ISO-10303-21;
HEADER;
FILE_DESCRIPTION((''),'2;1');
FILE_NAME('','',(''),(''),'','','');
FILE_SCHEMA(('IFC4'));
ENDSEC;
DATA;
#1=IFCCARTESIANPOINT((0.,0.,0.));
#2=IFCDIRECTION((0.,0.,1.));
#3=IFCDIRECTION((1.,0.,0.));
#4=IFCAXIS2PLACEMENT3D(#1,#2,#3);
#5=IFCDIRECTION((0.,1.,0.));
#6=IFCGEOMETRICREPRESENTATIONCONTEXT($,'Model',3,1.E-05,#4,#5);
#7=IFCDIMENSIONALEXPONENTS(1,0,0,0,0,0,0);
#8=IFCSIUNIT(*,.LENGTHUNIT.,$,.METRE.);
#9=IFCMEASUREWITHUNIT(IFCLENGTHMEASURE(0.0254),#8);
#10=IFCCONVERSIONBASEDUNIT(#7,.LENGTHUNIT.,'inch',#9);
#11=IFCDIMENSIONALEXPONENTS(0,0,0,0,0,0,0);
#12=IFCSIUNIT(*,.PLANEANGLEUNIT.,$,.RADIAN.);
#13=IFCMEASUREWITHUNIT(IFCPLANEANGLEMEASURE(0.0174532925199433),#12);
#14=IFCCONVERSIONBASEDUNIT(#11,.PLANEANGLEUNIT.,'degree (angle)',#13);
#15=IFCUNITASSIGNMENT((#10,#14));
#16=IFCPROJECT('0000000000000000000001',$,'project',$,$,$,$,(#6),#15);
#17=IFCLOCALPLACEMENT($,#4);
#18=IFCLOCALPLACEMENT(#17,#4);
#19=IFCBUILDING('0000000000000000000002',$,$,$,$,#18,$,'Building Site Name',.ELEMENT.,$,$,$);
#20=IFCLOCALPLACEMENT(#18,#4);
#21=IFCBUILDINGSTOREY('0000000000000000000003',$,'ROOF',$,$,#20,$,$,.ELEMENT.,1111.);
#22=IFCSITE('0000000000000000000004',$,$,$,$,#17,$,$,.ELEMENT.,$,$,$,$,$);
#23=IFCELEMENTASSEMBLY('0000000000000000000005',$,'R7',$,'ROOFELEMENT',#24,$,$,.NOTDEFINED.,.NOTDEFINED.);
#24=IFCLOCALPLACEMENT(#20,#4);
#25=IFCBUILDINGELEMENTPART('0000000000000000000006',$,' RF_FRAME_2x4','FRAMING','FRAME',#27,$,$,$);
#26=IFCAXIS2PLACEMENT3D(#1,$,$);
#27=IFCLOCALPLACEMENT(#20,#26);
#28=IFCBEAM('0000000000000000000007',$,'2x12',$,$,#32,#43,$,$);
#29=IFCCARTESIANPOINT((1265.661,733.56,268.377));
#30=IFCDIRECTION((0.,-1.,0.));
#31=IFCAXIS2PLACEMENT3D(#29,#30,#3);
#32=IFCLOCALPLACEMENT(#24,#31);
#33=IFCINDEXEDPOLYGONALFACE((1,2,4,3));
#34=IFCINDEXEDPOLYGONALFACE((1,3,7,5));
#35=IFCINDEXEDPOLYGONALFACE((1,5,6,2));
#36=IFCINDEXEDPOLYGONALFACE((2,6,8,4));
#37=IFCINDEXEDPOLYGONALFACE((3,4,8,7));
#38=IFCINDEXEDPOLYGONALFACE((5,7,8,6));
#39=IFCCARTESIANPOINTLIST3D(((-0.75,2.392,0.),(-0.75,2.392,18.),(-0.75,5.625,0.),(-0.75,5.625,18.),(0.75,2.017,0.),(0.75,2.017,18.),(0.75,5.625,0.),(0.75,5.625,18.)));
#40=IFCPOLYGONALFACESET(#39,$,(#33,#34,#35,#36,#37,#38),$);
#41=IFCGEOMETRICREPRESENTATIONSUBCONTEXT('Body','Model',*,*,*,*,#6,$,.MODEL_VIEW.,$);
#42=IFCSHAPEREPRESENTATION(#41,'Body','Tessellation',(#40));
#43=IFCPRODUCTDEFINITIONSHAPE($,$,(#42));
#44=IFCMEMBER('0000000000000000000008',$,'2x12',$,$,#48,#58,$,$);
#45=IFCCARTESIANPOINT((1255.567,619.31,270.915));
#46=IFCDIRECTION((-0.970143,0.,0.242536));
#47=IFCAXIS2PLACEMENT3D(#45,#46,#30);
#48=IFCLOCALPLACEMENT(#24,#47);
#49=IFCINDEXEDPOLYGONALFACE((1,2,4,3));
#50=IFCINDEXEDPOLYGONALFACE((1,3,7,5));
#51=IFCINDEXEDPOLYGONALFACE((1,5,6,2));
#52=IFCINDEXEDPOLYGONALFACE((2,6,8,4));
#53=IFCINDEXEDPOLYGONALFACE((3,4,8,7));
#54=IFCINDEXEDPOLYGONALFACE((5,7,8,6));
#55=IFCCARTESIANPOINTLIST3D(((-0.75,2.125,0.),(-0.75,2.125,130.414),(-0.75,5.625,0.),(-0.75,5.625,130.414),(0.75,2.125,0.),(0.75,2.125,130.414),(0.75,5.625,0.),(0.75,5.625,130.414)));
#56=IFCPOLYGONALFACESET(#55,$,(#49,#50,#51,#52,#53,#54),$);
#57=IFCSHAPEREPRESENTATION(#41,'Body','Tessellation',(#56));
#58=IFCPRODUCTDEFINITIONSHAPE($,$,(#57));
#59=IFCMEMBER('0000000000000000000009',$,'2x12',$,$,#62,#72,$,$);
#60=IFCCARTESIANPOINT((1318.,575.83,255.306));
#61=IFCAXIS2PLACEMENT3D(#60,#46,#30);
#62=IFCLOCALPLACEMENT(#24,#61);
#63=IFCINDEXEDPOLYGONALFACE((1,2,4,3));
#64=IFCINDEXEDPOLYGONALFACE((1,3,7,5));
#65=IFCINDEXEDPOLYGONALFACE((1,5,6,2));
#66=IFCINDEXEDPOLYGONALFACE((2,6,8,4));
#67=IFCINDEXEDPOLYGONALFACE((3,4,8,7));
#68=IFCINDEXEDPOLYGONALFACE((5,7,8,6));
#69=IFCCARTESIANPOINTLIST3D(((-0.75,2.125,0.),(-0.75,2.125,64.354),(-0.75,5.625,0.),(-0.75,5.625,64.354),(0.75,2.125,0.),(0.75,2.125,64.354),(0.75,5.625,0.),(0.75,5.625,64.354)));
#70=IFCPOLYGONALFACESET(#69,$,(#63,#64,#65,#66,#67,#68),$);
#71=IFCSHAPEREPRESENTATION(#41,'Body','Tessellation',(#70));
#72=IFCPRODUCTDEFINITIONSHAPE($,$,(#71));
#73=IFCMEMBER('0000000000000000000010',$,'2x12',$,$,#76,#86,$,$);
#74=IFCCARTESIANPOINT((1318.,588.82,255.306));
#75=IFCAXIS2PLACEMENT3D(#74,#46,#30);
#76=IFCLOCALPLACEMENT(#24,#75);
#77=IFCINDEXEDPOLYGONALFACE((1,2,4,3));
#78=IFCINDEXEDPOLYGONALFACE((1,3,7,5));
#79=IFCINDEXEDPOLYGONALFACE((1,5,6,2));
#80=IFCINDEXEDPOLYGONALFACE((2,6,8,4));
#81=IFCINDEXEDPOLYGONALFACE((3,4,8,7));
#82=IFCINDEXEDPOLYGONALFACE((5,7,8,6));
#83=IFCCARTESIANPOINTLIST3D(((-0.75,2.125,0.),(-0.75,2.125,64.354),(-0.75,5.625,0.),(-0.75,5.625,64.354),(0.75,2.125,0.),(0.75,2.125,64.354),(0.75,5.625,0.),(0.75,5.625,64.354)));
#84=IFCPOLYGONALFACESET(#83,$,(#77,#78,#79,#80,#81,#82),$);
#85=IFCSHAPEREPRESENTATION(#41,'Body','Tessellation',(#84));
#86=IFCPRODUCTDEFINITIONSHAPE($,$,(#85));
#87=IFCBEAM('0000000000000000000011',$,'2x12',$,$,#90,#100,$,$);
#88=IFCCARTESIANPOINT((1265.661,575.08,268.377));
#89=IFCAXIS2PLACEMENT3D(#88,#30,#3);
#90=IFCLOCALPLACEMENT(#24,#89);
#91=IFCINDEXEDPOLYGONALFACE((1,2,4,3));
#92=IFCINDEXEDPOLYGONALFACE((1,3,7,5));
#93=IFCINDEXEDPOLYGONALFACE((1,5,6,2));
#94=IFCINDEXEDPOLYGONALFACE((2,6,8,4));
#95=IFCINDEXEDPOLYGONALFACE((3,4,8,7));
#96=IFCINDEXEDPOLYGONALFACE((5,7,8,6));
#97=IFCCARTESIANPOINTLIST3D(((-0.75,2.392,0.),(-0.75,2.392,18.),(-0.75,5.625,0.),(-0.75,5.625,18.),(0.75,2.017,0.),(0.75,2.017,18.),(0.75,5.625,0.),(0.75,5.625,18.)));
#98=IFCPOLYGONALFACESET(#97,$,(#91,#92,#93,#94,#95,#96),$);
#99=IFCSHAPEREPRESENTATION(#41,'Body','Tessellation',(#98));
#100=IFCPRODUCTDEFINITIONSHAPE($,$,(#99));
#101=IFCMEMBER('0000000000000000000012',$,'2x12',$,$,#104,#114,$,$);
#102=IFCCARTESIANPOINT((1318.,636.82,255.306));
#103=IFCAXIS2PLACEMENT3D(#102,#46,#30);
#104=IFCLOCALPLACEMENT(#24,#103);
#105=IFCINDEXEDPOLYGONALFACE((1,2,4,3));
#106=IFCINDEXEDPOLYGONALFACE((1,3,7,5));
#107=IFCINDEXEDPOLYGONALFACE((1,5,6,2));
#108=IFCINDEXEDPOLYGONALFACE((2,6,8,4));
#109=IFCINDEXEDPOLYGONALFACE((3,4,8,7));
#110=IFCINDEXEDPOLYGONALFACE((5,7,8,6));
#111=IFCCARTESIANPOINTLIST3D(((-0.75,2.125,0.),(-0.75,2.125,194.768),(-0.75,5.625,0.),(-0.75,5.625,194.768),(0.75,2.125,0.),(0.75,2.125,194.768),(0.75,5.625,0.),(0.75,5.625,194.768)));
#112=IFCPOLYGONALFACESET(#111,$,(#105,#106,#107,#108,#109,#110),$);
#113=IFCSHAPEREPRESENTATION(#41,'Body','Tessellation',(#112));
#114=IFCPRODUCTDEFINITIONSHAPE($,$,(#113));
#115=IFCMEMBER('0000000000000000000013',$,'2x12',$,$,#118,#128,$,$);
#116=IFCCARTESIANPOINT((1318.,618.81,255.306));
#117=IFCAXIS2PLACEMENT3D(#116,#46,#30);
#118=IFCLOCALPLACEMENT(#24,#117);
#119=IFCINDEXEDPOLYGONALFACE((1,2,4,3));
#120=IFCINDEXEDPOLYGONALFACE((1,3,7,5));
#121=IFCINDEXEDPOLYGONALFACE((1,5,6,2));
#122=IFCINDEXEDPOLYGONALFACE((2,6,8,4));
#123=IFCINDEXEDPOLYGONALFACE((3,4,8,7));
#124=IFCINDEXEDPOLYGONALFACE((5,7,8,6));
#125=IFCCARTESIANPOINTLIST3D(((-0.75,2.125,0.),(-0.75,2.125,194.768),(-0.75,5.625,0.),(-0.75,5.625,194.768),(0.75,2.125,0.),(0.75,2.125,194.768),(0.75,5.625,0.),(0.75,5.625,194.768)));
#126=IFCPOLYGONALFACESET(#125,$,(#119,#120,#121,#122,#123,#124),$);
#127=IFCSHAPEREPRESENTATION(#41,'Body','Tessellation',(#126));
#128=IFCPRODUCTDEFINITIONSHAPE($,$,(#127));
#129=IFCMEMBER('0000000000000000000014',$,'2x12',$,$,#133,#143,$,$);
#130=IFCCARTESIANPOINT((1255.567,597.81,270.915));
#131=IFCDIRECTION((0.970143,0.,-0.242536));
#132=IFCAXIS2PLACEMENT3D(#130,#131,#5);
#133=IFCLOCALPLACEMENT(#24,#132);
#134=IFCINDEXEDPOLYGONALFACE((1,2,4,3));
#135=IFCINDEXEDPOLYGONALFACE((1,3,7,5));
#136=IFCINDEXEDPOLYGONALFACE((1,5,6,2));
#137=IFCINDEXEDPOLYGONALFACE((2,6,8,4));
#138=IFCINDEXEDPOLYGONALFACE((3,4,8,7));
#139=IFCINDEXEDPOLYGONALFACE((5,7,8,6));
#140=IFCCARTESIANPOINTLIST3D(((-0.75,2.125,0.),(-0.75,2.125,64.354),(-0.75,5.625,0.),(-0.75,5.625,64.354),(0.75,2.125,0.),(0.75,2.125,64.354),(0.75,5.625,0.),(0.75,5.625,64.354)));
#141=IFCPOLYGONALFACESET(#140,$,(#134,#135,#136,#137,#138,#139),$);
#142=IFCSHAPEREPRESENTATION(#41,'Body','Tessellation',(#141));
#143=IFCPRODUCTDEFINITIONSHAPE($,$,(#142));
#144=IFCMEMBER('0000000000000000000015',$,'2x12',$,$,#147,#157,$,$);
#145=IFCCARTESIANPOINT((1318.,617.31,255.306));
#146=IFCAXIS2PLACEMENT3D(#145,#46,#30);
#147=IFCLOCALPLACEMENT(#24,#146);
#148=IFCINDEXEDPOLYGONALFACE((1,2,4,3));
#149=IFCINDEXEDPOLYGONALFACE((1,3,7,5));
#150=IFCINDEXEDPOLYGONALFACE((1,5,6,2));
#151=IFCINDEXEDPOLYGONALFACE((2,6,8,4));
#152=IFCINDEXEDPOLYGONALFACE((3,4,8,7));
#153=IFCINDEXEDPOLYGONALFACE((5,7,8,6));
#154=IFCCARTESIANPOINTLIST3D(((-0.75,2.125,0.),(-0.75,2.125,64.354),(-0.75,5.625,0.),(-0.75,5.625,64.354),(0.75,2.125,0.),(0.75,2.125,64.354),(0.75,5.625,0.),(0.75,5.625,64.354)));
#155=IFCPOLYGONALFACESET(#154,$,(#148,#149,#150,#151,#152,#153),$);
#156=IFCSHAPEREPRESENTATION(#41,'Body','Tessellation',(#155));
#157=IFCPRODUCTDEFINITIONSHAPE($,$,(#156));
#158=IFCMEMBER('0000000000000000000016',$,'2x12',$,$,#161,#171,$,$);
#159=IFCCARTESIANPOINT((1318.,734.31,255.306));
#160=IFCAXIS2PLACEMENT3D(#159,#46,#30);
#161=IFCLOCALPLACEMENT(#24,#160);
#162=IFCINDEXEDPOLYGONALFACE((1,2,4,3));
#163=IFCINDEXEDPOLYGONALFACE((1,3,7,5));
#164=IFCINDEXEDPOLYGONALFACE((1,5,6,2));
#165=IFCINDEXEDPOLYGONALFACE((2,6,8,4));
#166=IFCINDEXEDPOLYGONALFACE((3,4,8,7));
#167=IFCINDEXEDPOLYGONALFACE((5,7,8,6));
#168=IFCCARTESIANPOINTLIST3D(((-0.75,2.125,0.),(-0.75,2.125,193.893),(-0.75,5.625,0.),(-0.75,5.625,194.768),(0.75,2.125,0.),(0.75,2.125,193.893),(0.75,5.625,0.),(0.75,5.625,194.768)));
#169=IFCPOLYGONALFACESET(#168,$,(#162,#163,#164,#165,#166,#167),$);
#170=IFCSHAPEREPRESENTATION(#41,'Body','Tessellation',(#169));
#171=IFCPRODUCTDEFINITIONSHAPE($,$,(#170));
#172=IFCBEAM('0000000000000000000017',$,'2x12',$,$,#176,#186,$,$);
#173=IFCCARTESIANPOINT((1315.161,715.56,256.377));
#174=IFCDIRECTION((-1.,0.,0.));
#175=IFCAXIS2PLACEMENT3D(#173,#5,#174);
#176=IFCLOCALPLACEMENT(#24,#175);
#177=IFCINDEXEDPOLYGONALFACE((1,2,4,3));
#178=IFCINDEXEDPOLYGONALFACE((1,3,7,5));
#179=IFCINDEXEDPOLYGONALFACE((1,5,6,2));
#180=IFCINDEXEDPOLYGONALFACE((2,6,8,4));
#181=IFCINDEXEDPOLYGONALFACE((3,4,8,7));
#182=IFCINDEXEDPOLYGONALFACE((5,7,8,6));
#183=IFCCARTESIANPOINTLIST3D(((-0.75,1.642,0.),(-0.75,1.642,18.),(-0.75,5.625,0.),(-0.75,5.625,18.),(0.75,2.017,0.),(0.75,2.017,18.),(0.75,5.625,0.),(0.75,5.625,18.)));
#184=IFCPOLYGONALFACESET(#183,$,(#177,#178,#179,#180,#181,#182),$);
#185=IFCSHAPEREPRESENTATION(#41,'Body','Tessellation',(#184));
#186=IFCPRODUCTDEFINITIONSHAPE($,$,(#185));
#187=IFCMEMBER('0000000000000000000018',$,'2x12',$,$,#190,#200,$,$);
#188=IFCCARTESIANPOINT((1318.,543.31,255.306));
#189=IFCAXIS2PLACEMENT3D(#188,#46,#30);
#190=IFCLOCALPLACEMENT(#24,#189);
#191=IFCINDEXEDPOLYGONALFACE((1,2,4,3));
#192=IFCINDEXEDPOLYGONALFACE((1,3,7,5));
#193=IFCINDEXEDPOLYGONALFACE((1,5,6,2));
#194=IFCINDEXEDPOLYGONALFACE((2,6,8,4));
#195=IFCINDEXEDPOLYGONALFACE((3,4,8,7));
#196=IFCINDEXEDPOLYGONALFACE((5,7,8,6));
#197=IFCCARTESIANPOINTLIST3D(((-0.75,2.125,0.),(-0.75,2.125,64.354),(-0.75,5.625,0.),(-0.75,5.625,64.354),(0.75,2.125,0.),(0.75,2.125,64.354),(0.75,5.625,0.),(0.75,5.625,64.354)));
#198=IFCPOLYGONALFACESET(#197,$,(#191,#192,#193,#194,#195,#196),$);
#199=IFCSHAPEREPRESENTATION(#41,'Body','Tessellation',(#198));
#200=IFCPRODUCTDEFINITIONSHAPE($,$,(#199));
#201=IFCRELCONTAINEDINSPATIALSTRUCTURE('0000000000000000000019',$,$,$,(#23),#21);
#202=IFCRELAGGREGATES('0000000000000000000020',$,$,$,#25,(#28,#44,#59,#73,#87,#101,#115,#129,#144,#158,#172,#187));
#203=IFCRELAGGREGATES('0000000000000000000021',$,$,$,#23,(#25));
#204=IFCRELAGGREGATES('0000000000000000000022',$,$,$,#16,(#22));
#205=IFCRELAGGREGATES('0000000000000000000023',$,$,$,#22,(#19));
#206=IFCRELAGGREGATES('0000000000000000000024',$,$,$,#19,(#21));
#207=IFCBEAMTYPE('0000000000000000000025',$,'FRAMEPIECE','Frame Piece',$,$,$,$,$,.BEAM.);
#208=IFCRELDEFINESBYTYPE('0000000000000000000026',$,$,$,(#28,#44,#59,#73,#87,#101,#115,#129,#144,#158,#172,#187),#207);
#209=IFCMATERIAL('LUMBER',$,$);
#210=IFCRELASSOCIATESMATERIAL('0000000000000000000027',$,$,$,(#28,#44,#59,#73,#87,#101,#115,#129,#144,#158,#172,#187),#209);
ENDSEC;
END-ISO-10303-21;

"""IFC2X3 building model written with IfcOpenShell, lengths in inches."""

from ifc_helpers import new_model, entity, si_unit, converted_unit, direction, frame, frame_2d, origin_with_axes, place, context, subcontext, project, spatial, polyline, segment, composite_curve, rectangle, outline, extrude, clip, halfspace, material, type_object, element, aggregate, save


model = new_model("IFC2X3")

# Units and contexts
model_context = context("Model", 3, precision=1e-05, world=origin_with_axes(), true_north=direction((0.0, 1.0, 0.0)))
body_context = subcontext(model_context, "Body", "Model", "MODEL_VIEW")
ifc_project = project(units=[converted_unit("LENGTHUNIT", "inch", entity("IfcLengthMeasure", 0.0254), si_unit("LENGTHUNIT", "METRE"), dimensions=[1, 0, 0, 0, 0, 0, 0]), converted_unit("PLANEANGLEUNIT", "degree (angle)", entity("IfcPlaneAngleMeasure", 0.0174532925199433), si_unit("PLANEANGLEUNIT", "RADIAN"), dimensions=[0, 0, 0, 0, 0, 0, 0])], contexts=[model_context])

# Site, building, storey
site_placement = place(None, origin_with_axes())
site = spatial("IfcSite", under=ifc_project, at=site_placement, CompositionType="ELEMENT")
building_placement = place(site_placement, origin_with_axes())
building = spatial("IfcBuilding", under=site, at=building_placement, LongName="Building Site Name", CompositionType="ELEMENT")
storey_placement = place(building_placement, origin_with_axes())
storey = spatial("IfcBuildingStorey", under=building, at=storey_placement, Name="ROOF", CompositionType="ELEMENT", Elevation=1111.0)

# Element assembly, building element part, beams, members
assembly_placement = place(storey_placement, origin_with_axes())
assembly = element("IfcElementAssembly", 1, at=assembly_placement, inside=storey, Name="R7", ObjectType="ROOFELEMENT", AssemblyPlace="NOTDEFINED", PredefinedType="NOTDEFINED")
building_element_part_1 = element("IfcBuildingElementPart", 2, Name=" RF_FRAME_2x4", Description="FRAMING", ObjectType="FRAME")
ifc_material_1 = material(Name="LUMBER")
beam_type = type_object("IfcBeamType", Name="FRAMEPIECE", Description="Frame Piece", PredefinedType="BEAM")
beam_1_placement = place(assembly_placement, frame((1265.661, 733.56, 268.377), z_axis=(0.0, -1.0, 0.0), x_axis=(1.0, 0.0, 0.0)))
beam_1 = element("IfcBeam", 3, at=beam_1_placement, type_object=beam_type, material=ifc_material_1, Name="2x12", context=body_context, shape_type="SweptSolid", body=[
    extrude(outline(composite_curve([segment(polyline([(-0.75, 2.392), (0.75, 2.017), (0.75, 5.625), (-0.75, 5.625), (-0.75, 2.392)]), True, "CONTINUOUS")], self_intersect=False)), frame((0.0, 0.0, 0.0), z_axis=(0.0, 0.0, 1.0), x_axis=(1.0, 0.0, 0.0)), (0.0, 0.0, 1.0), 18.0),
])
member_1_placement = place(assembly_placement, frame((1255.567, 619.31, 270.915), z_axis=(-0.970143, 0.0, 0.242536), x_axis=(0.0, -1.0, 0.0)))
member_1 = element("IfcMember", 4, at=member_1_placement, type_object=beam_type, material=ifc_material_1, Name="2x12", context=body_context, shape_type="SweptSolid", body=[
    extrude(rectangle(XDim=3.5, YDim=1.5, at=frame_2d((0.0, 3.875), x_axis=(0.0, -1.0))), frame((0.0, 0.0, 0.0), z_axis=(0.0, 0.0, 1.0), x_axis=(1.0, 0.0, 0.0)), (0.0, 0.0, 1.0), 130.414),
])
member_2_placement = place(assembly_placement, frame((1318.0, 575.83, 255.306), z_axis=(-0.970143, 0.0, 0.242536), x_axis=(0.0, -1.0, 0.0)))
member_2 = element("IfcMember", 5, at=member_2_placement, type_object=beam_type, material=ifc_material_1, Name="2x12", context=body_context, shape_type="SweptSolid", body=[
    extrude(rectangle(XDim=3.5, YDim=1.5, at=frame_2d((0.0, 3.875), x_axis=(0.0, -1.0))), frame((0.0, 0.0, 0.0), z_axis=(0.0, 0.0, 1.0), x_axis=(1.0, 0.0, 0.0)), (0.0, 0.0, 1.0), 64.354),
])
member_3_placement = place(assembly_placement, frame((1318.0, 588.82, 255.306), z_axis=(-0.970143, 0.0, 0.242536), x_axis=(0.0, -1.0, 0.0)))
member_3 = element("IfcMember", 6, at=member_3_placement, type_object=beam_type, material=ifc_material_1, Name="2x12", context=body_context, shape_type="SweptSolid", body=[
    extrude(rectangle(XDim=3.5, YDim=1.5, at=frame_2d((0.0, 3.875), x_axis=(0.0, -1.0))), frame((0.0, 0.0, 0.0), z_axis=(0.0, 0.0, 1.0), x_axis=(1.0, 0.0, 0.0)), (0.0, 0.0, 1.0), 64.354),
])
beam_2_placement = place(assembly_placement, frame((1265.661, 575.08, 268.377), z_axis=(0.0, -1.0, 0.0), x_axis=(1.0, 0.0, 0.0)))
beam_2 = element("IfcBeam", 7, at=beam_2_placement, type_object=beam_type, material=ifc_material_1, Name="2x12", context=body_context, shape_type="SweptSolid", body=[
    extrude(outline(composite_curve([segment(polyline([(-0.75, 2.392), (0.75, 2.017), (0.75, 5.625), (-0.75, 5.625), (-0.75, 2.392)]), True, "CONTINUOUS")], self_intersect=False)), origin_with_axes(), (0.0, 0.0, 1.0), 18.0),
])
member_4_placement = place(assembly_placement, frame((1318.0, 636.82, 255.306), z_axis=(-0.970143, 0.0, 0.242536), x_axis=(0.0, -1.0, 0.0)))
member_4 = element("IfcMember", 8, at=member_4_placement, type_object=beam_type, material=ifc_material_1, Name="2x12", context=body_context, shape_type="SweptSolid", body=[
    extrude(rectangle(XDim=3.5, YDim=1.5, at=frame_2d((0.0, 3.875), x_axis=(0.0, -1.0))), frame((0.0, 0.0, 0.0), z_axis=(0.0, 0.0, 1.0), x_axis=(1.0, 0.0, 0.0)), (0.0, 0.0, 1.0), 194.768),
])
member_5_placement = place(assembly_placement, frame((1318.0, 618.81, 255.306), z_axis=(-0.970143, 0.0, 0.242536), x_axis=(0.0, -1.0, 0.0)))
member_5 = element("IfcMember", 9, at=member_5_placement, type_object=beam_type, material=ifc_material_1, Name="2x12", context=body_context, shape_type="SweptSolid", body=[
    extrude(rectangle(XDim=3.5, YDim=1.5, at=frame_2d((0.0, 3.875), x_axis=(0.0, -1.0))), frame((0.0, 0.0, 0.0), z_axis=(0.0, 0.0, 1.0), x_axis=(1.0, 0.0, 0.0)), (0.0, 0.0, 1.0), 194.768),
])
member_6_placement = place(assembly_placement, frame((1255.567, 597.81, 270.915), z_axis=(0.970143, 0.0, -0.242536), x_axis=(0.0, 1.0, 0.0)))
member_6 = element("IfcMember", 10, at=member_6_placement, type_object=beam_type, material=ifc_material_1, Name="2x12", context=body_context, shape_type="SweptSolid", body=[
    extrude(rectangle(XDim=3.5, YDim=1.5, at=frame_2d((0.0, 3.875), x_axis=(0.0, -1.0))), frame((0.0, 0.0, 0.0), z_axis=(0.0, 0.0, 1.0), x_axis=(1.0, 0.0, 0.0)), (0.0, 0.0, 1.0), 64.354),
])
member_7_placement = place(assembly_placement, frame((1318.0, 617.31, 255.306), z_axis=(-0.970143, 0.0, 0.242536), x_axis=(0.0, -1.0, 0.0)))
member_7 = element("IfcMember", 11, at=member_7_placement, type_object=beam_type, material=ifc_material_1, Name="2x12", context=body_context, shape_type="SweptSolid", body=[
    extrude(rectangle(XDim=3.5, YDim=1.5, at=frame_2d((0.0, 3.875), x_axis=(0.0, -1.0))), frame((0.0, 0.0, 0.0), z_axis=(0.0, 0.0, 1.0), x_axis=(1.0, 0.0, 0.0)), (0.0, 0.0, 1.0), 64.354),
])
member_8_placement = place(assembly_placement, frame((1318.0, 734.31, 255.306), z_axis=(-0.970143, 0.0, 0.242536), x_axis=(0.0, -1.0, 0.0)))
member_8 = element("IfcMember", 12, at=member_8_placement, type_object=beam_type, material=ifc_material_1, Name="2x12", context=body_context, shape_type="Clipping", body=[
    clip(extrude(rectangle(XDim=3.5, YDim=1.5, at=frame_2d((0.0, 3.875), x_axis=(0.0, -1.0))), frame((0.0, 0.0, 0.0), z_axis=(0.0, 0.0, 1.0), x_axis=(1.0, 0.0, 0.0)), (0.0, 0.0, 1.0), 292.152), halfspace(frame((-0.75, 2.125, 193.893), z_axis=(0.0, 0.242536, -0.970143), x_axis=(0.0, -0.970143, -0.242536)), True)),
])
beam_3_placement = place(assembly_placement, frame((1315.161, 715.56, 256.377), z_axis=(0.0, 1.0, 0.0), x_axis=(-1.0, 0.0, 0.0)))
beam_3 = element("IfcBeam", 13, at=beam_3_placement, type_object=beam_type, material=ifc_material_1, Name="2x12", context=body_context, shape_type="SweptSolid", body=[
    extrude(outline(composite_curve([segment(polyline([(-0.75, 1.642), (0.75, 2.017), (0.75, 5.625), (-0.75, 5.625), (-0.75, 1.642)]), True, "CONTINUOUS")], self_intersect=False)), origin_with_axes(), (0.0, 0.0, 1.0), 18.0),
])
member_9_placement = place(assembly_placement, frame((1318.0, 543.31, 255.306), z_axis=(-0.970143, 0.0, 0.242536), x_axis=(0.0, -1.0, 0.0)))
member_9 = element("IfcMember", 14, at=member_9_placement, type_object=beam_type, material=ifc_material_1, Name="2x12", context=body_context, shape_type="SweptSolid", body=[
    extrude(rectangle(XDim=3.5, YDim=1.5, at=frame_2d((0.0, 3.875), x_axis=(0.0, -1.0))), frame((0.0, 0.0, 0.0), z_axis=(0.0, 0.0, 1.0), x_axis=(1.0, 0.0, 0.0)), (0.0, 0.0, 1.0), 64.354),
])
aggregate(building_element_part_1, [beam_1, member_1, member_2, member_3, beam_2, member_4, member_5, member_6, member_7, member_8, beam_3, member_9])
aggregate(assembly, [building_element_part_1])

save(model, "model.ifc")
